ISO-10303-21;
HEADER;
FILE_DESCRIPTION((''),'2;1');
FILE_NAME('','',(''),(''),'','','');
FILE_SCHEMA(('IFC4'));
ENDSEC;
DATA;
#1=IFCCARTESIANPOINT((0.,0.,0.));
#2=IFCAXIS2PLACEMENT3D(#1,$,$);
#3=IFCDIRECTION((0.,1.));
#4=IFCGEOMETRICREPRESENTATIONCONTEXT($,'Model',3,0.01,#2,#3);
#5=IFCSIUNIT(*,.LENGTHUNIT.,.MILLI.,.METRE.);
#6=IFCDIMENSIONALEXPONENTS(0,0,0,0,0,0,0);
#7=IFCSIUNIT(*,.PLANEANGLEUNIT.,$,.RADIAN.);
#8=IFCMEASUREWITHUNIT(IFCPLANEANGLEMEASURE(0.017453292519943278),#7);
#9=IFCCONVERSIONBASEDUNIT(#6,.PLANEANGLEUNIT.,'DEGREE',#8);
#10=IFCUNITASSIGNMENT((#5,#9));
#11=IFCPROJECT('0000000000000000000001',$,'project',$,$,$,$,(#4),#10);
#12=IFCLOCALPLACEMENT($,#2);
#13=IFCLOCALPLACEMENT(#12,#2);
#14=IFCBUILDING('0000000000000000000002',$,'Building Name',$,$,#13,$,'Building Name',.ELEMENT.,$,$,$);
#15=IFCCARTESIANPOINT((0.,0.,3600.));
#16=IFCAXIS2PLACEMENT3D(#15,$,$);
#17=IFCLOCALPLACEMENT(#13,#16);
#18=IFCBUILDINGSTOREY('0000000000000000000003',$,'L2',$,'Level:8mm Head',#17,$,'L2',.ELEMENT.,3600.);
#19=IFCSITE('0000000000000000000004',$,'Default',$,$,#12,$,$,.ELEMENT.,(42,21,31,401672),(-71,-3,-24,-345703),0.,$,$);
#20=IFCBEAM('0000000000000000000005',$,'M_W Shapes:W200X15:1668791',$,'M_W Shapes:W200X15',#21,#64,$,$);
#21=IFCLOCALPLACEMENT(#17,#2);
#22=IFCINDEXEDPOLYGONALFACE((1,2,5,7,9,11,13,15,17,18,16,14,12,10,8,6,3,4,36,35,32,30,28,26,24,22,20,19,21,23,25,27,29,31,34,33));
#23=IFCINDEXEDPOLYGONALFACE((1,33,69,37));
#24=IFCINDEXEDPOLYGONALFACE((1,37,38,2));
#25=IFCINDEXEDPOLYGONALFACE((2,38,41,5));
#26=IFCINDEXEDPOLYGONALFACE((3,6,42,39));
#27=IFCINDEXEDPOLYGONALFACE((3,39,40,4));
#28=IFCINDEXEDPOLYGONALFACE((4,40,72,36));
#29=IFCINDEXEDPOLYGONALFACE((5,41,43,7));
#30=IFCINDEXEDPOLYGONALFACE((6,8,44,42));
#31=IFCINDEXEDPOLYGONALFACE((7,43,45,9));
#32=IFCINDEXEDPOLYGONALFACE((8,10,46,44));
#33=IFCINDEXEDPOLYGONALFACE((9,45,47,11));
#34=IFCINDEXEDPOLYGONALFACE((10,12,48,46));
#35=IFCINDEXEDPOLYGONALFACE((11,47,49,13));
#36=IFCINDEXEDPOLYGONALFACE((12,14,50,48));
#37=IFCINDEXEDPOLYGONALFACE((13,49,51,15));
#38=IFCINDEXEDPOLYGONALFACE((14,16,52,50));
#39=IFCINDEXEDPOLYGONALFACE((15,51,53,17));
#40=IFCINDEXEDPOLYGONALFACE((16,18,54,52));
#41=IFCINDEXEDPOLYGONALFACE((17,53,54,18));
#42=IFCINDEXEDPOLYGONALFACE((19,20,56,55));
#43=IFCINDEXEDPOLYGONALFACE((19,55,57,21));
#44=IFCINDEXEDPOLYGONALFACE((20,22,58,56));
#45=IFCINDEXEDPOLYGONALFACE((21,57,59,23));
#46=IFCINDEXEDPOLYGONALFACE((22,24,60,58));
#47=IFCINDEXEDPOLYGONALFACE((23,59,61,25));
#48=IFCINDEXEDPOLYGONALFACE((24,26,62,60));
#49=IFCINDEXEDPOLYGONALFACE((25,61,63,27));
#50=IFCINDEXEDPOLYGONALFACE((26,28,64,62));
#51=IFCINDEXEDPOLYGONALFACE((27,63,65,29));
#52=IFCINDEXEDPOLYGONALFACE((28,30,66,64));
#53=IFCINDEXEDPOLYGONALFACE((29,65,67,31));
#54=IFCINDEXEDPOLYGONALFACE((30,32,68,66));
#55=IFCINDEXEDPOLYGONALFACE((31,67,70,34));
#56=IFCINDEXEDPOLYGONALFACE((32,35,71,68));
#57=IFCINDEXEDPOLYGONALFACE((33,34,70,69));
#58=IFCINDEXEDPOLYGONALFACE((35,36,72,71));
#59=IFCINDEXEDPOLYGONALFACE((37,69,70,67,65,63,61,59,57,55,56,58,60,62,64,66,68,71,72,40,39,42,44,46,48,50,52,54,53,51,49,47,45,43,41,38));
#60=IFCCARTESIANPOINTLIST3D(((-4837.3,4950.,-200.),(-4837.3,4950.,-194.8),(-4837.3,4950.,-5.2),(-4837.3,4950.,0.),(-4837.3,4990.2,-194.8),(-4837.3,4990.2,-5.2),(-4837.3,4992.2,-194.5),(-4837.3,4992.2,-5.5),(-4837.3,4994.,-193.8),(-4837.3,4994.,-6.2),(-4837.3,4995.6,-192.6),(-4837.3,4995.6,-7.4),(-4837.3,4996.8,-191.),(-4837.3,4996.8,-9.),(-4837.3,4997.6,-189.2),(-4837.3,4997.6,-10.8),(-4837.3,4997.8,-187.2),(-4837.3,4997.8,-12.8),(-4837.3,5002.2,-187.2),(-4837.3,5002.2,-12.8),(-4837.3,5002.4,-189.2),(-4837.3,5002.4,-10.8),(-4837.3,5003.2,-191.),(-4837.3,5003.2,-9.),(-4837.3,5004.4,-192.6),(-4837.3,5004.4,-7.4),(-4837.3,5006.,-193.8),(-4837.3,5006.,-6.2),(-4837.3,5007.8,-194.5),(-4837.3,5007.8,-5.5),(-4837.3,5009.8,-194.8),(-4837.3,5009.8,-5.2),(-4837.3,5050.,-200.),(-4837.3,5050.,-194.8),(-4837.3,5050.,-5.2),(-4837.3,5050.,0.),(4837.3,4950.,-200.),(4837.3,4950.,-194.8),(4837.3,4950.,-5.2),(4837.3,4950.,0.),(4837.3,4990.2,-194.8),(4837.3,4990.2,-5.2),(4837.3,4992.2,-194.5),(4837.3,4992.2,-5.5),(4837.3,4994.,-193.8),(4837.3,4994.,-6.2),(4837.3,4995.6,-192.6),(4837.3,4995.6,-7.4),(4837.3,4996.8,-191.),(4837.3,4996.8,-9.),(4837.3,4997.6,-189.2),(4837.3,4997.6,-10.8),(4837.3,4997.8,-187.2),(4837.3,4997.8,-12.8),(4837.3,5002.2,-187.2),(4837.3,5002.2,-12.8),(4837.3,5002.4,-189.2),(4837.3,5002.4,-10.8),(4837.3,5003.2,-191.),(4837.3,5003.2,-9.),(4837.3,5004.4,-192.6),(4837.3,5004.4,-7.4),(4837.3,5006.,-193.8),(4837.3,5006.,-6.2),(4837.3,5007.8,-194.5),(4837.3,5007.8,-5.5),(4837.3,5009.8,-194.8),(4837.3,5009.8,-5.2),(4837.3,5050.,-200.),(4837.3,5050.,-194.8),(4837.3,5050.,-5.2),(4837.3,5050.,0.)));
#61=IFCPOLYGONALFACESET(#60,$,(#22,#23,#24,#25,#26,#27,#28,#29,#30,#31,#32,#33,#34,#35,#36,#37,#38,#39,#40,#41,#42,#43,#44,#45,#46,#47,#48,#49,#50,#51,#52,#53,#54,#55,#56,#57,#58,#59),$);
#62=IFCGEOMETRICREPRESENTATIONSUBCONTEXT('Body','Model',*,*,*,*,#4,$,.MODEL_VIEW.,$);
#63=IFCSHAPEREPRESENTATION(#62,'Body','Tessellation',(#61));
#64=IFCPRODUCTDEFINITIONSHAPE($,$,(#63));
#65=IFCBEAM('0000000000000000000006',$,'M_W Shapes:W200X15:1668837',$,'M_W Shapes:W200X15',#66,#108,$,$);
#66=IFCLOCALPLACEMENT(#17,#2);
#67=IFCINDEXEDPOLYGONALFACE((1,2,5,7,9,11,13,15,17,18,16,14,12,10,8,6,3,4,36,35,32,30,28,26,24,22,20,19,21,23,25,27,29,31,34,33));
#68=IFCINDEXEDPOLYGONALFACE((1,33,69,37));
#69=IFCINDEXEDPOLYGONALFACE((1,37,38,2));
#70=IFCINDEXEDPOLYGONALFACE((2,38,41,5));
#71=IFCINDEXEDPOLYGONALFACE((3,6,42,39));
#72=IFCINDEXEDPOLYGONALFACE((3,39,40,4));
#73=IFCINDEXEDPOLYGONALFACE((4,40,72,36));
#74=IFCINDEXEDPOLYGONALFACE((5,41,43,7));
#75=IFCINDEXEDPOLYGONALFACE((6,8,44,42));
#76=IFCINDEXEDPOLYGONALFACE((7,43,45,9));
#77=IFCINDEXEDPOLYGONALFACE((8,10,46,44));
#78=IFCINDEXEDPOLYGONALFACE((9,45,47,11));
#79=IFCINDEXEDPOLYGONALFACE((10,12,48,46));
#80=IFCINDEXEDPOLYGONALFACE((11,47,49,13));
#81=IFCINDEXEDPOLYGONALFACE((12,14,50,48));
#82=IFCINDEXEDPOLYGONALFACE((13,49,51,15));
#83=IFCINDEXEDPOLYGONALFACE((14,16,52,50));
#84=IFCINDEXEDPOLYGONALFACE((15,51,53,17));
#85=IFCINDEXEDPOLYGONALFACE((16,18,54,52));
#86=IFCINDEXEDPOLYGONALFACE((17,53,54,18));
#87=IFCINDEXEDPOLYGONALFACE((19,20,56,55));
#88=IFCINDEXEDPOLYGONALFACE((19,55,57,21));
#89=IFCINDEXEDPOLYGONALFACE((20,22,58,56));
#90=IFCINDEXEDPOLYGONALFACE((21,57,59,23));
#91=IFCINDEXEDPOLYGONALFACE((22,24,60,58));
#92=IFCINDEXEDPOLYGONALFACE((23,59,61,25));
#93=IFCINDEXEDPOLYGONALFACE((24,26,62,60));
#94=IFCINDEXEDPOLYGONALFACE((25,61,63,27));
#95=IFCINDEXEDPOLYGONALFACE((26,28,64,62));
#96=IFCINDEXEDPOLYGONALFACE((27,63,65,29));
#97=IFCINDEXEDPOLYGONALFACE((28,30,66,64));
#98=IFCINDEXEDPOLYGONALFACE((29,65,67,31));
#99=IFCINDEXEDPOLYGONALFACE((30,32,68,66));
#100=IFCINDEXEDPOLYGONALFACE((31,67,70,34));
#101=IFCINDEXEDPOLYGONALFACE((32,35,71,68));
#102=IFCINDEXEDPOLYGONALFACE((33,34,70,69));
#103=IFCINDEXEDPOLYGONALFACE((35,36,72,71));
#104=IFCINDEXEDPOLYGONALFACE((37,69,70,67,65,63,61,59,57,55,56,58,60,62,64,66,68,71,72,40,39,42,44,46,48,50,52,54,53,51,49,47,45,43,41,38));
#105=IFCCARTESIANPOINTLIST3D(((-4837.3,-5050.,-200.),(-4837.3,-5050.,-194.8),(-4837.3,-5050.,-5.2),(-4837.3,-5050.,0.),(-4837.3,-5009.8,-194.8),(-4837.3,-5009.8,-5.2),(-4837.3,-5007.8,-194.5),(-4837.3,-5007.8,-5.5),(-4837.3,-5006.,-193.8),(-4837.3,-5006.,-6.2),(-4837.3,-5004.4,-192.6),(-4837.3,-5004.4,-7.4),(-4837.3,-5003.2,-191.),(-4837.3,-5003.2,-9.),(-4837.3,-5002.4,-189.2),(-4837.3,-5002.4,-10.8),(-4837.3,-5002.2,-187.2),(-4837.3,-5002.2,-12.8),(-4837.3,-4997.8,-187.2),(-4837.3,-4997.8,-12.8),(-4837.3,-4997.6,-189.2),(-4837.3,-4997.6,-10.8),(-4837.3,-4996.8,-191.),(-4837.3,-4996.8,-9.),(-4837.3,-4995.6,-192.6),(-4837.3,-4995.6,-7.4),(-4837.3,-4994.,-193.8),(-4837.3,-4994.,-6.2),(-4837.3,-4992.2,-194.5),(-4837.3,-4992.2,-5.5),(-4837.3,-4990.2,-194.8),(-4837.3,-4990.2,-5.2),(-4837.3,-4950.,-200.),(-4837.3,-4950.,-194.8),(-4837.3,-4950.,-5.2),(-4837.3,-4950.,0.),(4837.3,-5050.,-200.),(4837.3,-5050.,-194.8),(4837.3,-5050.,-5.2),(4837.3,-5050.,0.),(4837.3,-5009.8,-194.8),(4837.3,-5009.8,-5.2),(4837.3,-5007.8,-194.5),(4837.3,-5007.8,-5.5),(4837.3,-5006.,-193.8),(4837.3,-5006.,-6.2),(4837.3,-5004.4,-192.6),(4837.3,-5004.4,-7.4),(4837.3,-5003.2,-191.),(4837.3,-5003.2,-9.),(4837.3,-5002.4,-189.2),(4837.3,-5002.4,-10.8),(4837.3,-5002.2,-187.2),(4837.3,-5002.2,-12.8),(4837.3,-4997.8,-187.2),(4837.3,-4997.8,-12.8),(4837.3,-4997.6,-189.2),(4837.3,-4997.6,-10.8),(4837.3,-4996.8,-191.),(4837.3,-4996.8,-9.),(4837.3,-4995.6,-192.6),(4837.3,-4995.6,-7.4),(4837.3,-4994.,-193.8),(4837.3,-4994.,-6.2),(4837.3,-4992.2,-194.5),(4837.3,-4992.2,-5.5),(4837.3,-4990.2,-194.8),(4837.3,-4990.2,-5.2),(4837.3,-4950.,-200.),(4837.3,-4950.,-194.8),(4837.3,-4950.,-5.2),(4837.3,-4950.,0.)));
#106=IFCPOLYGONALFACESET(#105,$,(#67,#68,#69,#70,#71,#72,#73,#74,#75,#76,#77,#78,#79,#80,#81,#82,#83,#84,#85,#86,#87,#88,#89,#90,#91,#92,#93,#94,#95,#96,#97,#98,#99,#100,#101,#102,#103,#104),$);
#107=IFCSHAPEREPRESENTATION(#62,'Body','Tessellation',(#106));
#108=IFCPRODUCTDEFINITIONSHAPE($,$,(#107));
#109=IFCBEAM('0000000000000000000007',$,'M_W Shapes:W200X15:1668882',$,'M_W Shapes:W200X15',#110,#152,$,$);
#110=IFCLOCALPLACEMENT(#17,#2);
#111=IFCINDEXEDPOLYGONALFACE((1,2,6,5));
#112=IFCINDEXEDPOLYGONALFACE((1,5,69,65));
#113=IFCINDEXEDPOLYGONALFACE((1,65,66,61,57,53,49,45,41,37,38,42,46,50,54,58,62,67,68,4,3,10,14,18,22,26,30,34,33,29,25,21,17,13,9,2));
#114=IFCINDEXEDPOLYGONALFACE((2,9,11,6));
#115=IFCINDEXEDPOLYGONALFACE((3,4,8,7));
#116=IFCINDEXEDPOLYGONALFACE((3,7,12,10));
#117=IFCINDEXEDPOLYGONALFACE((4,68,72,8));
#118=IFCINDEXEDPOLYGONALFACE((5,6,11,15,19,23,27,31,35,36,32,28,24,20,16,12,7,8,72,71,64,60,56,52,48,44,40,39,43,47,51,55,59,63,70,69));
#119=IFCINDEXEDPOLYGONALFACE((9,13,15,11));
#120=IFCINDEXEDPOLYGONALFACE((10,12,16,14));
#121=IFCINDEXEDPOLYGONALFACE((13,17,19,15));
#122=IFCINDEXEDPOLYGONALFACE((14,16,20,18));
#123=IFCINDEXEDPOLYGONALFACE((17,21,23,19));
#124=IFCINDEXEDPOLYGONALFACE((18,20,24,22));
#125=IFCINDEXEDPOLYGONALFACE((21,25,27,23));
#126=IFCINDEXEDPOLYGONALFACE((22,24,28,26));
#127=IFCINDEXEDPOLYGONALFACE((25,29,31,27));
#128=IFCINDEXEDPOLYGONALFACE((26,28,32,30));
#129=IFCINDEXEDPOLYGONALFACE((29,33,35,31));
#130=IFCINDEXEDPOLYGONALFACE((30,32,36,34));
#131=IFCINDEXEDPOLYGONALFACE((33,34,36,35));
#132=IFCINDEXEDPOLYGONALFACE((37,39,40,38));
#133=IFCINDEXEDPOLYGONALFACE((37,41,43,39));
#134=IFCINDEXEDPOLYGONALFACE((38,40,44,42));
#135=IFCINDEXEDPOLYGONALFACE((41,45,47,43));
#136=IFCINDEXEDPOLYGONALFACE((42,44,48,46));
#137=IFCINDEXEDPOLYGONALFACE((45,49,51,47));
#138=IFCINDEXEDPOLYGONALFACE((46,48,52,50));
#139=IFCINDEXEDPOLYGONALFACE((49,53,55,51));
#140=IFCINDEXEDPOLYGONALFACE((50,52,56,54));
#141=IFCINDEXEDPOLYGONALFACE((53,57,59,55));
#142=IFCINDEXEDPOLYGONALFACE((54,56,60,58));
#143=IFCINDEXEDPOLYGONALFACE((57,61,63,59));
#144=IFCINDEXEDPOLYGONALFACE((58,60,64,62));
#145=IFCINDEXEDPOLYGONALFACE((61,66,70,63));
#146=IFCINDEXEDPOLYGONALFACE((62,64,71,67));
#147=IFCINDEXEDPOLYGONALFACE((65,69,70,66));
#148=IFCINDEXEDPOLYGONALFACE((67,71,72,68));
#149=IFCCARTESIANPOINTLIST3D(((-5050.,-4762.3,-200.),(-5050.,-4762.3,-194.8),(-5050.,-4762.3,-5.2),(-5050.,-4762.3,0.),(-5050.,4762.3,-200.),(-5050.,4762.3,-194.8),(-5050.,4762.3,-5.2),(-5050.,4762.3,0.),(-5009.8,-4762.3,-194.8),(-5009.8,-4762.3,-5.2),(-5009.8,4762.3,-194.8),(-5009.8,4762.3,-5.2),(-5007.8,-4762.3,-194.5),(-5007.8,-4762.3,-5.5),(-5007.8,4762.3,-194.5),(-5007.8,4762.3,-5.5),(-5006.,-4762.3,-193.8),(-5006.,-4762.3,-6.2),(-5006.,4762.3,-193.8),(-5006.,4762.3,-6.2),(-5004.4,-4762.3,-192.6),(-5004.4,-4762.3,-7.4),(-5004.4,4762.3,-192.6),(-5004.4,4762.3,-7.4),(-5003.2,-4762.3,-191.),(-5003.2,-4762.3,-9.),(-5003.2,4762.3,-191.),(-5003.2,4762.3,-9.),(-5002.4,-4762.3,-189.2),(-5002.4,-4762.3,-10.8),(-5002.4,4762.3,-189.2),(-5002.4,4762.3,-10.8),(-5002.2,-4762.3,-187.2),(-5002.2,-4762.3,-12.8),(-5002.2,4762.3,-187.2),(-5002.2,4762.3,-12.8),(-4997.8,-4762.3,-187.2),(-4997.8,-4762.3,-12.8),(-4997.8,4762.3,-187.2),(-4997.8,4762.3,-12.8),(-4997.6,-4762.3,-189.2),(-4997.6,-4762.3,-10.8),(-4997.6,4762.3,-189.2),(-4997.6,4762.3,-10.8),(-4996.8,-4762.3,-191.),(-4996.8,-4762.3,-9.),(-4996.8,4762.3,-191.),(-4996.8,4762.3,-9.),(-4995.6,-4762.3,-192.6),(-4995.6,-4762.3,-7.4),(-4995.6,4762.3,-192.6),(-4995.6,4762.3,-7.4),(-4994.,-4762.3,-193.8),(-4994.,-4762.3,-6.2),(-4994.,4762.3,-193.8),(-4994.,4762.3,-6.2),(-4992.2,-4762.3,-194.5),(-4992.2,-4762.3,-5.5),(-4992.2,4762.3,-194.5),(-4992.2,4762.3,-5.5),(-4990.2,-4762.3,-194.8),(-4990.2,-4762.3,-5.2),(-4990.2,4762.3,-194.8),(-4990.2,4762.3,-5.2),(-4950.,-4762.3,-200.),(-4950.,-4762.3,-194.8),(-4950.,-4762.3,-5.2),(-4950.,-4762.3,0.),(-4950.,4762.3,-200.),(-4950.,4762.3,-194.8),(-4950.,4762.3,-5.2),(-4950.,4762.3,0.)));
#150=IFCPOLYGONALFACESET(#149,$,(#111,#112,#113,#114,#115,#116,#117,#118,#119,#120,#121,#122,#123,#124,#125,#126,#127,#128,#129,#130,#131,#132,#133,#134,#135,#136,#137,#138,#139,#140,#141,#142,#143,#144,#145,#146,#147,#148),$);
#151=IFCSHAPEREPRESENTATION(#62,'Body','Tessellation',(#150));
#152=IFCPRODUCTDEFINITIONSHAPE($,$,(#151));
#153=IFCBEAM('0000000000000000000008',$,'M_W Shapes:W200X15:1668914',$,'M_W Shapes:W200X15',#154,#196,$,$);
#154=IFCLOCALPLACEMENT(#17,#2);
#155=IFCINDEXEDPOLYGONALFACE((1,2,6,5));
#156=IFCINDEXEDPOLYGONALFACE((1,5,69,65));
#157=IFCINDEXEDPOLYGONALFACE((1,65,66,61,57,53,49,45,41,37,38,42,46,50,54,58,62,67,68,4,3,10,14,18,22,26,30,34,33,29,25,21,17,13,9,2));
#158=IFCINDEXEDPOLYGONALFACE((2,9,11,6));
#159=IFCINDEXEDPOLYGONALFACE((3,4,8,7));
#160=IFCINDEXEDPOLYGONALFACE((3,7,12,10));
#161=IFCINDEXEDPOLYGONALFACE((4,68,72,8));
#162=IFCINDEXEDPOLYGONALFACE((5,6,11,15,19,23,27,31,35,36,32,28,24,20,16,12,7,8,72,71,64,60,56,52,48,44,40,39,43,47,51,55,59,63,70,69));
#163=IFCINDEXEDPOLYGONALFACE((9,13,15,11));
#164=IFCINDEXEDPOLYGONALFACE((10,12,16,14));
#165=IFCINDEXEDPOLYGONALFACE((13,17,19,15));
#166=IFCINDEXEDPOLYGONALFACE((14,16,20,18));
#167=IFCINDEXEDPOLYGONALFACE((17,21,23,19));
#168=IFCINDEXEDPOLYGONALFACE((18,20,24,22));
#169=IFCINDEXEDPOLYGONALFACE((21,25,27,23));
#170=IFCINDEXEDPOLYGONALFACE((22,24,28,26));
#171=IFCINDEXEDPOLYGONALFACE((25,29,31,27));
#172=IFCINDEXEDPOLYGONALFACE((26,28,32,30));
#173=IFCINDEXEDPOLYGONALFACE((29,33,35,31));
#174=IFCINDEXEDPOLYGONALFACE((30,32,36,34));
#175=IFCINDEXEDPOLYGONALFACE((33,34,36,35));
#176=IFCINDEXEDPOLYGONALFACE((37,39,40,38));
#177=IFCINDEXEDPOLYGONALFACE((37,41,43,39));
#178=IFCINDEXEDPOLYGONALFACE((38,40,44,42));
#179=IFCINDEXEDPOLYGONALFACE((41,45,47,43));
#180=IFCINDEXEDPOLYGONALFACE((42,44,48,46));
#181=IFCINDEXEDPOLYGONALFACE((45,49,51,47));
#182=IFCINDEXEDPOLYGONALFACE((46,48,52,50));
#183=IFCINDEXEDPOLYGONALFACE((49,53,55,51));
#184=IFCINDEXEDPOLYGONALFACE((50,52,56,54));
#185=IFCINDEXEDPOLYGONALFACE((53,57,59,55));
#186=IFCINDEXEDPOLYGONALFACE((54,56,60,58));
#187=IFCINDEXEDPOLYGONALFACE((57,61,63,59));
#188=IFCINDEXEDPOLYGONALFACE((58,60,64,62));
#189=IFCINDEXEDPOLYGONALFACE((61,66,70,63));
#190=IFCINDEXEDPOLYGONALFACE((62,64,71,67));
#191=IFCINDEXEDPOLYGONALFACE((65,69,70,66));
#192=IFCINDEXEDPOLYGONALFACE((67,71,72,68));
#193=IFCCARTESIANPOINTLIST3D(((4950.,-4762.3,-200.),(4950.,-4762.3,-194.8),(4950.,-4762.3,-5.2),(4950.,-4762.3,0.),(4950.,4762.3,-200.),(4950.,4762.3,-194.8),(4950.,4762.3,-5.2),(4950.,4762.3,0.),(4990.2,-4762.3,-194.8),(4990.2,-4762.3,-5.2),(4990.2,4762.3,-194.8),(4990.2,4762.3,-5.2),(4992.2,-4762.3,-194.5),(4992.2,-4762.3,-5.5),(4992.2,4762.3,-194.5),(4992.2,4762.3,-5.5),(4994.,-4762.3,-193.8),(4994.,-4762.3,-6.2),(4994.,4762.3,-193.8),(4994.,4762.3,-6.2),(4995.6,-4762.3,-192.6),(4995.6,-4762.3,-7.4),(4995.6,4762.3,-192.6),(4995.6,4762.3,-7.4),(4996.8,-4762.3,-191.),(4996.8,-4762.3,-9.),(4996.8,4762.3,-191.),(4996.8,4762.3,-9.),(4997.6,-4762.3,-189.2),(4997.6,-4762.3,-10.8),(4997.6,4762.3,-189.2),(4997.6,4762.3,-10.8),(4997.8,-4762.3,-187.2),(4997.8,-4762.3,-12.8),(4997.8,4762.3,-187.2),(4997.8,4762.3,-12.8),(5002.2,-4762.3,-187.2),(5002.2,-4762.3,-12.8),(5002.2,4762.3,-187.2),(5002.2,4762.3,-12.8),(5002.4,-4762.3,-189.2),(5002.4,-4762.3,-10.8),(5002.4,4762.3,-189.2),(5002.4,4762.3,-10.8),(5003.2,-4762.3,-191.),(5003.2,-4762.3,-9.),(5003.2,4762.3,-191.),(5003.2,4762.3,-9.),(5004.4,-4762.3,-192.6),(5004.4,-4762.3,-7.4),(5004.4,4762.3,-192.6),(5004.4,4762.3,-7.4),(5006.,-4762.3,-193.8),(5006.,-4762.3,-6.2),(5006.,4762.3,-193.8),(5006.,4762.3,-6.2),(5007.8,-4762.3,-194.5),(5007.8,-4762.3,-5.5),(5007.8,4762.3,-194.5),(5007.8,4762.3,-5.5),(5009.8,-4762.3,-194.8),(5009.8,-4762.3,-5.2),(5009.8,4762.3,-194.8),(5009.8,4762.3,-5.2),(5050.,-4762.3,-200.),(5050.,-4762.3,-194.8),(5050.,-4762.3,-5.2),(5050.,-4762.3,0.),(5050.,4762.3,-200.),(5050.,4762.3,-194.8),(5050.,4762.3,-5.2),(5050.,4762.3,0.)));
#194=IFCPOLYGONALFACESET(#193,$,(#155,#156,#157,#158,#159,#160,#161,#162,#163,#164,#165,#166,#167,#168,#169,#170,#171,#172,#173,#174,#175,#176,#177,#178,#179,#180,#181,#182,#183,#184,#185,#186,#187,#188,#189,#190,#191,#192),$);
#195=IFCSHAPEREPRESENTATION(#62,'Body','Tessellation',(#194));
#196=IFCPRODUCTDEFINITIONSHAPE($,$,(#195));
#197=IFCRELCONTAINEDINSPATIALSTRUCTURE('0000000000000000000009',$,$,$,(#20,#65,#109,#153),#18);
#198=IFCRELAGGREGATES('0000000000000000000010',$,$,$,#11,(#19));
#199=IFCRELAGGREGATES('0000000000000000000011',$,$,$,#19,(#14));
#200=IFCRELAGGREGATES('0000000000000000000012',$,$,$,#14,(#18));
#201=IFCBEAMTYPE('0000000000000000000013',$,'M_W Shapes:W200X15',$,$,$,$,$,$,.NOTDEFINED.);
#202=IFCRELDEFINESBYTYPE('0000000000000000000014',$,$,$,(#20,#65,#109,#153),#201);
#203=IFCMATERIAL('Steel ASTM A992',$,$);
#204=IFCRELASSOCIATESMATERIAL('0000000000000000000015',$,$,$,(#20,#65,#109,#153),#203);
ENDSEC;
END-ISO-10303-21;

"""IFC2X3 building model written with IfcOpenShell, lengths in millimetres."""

from ifc_helpers import new_model, entity, si_unit, converted_unit, direction, frame, frame_2d, origin, place, context, subcontext, project, spatial, i_section, extrude, material, type_object, element, save


model = new_model("IFC2X3")

# Units and contexts
model_context = context("Model", 3, precision=0.01, world=origin(), true_north=direction((0.0, 1.0)))
body_context = subcontext(model_context, "Body", "Model", "MODEL_VIEW")
ifc_project = project(units=[si_unit("LENGTHUNIT", "METRE", prefix="MILLI"), converted_unit("PLANEANGLEUNIT", "DEGREE", entity("IfcPlaneAngleMeasure", 0.017453292519943278), si_unit("PLANEANGLEUNIT", "RADIAN"), dimensions=[0, 0, 0, 0, 0, 0, 0])], contexts=[model_context])

# Site, building, storey
site_placement = place(None, origin())
site = spatial("IfcSite", under=ifc_project, at=site_placement, Name="Default", CompositionType="ELEMENT", RefLatitude=(42, 21, 31, 401672), RefLongitude=(-71, -3, -24, -345703), RefElevation=0.0)
building_placement = place(site_placement, origin())
building = spatial("IfcBuilding", under=site, at=building_placement, Name="Building Name", LongName="Building Name", CompositionType="ELEMENT")
storey_placement = place(building_placement, frame((0.0, 0.0, 3600.0)))
storey = spatial("IfcBuildingStorey", under=building, at=storey_placement, Name="L2", ObjectType="Level:8mm Head", LongName="L2", CompositionType="ELEMENT", Elevation=3600.0)

# Beams
ifc_material_1 = material(Name="Steel ASTM A992")
beam_type = type_object("IfcBeamType", Name="M_W Shapes:W200X15", PredefinedType="NOTDEFINED")
beam_1_placement = place(storey_placement, frame((-5000.0, 5000.0, 0.0)))
element("IfcBeam", 1, at=beam_1_placement, inside=storey, type_object=beam_type, material=ifc_material_1, Name="M_W Shapes:W200X15:1668791", ObjectType="M_W Shapes:W200X15", context=body_context, shape_type="SweptSolid", body=[
    extrude(i_section(OverallWidth=100.0, OverallDepth=200.0, WebThickness=4.3, FlangeThickness=5.2, FilletRadius=7.6, at=frame_2d((0.0, 0.0), x_axis=(0.0, 1.0))), frame((162.7, 0.0, -100.0), z_axis=(1.0, 0.0, 0.0), x_axis=(0.0, 0.0, -1.0)), (0.0, 0.0, 1.0), 9674.6),
])
beam_2_placement = place(storey_placement, frame((-5000.0, -5000.0, 0.0)))
element("IfcBeam", 2, at=beam_2_placement, inside=storey, type_object=beam_type, material=ifc_material_1, Name="M_W Shapes:W200X15:1668837", ObjectType="M_W Shapes:W200X15", context=body_context, shape_type="SweptSolid", body=[
    extrude(i_section(OverallWidth=100.0, OverallDepth=200.0, WebThickness=4.3, FlangeThickness=5.2, FilletRadius=7.6, at=frame_2d((0.0, 0.0), x_axis=(0.0, 1.0))), frame((162.7, 0.0, -100.0), z_axis=(1.0, 0.0, 0.0), x_axis=(0.0, 0.0, -1.0)), (0.0, 0.0, 1.0), 9674.6),
])
beam_3_placement = place(storey_placement, frame((-5000.0, -5000.0, 0.0), z_axis=(0.0, 0.0, 1.0), x_axis=(0.0, 1.0, 0.0)))
element("IfcBeam", 3, at=beam_3_placement, inside=storey, type_object=beam_type, material=ifc_material_1, Name="M_W Shapes:W200X15:1668882", ObjectType="M_W Shapes:W200X15", context=body_context, shape_type="SweptSolid", body=[
    extrude(i_section(OverallWidth=100.0, OverallDepth=200.0, WebThickness=4.3, FlangeThickness=5.2, FilletRadius=7.6, at=frame_2d((0.0, 0.0), x_axis=(0.0, 1.0))), frame((237.7, 0.0, -100.0), z_axis=(1.0, 0.0, 0.0), x_axis=(0.0, 0.0, -1.0)), (0.0, 0.0, 1.0), 9524.6),
])
beam_4_placement = place(storey_placement, frame((5000.0, -5000.0, 0.0), z_axis=(0.0, 0.0, 1.0), x_axis=(0.0, 1.0, 0.0)))
element("IfcBeam", 4, at=beam_4_placement, inside=storey, type_object=beam_type, material=ifc_material_1, Name="M_W Shapes:W200X15:1668914", ObjectType="M_W Shapes:W200X15", context=body_context, shape_type="SweptSolid", body=[
    extrude(i_section(OverallWidth=100.0, OverallDepth=200.0, WebThickness=4.3, FlangeThickness=5.2, FilletRadius=7.6, at=frame_2d((0.0, 0.0), x_axis=(0.0, 1.0))), frame((237.7, 0.0, -100.0), z_axis=(1.0, 0.0, 0.0), x_axis=(0.0, 0.0, -1.0)), (0.0, 0.0, 1.0), 9524.6),
])

save(model, "model.ifc")
